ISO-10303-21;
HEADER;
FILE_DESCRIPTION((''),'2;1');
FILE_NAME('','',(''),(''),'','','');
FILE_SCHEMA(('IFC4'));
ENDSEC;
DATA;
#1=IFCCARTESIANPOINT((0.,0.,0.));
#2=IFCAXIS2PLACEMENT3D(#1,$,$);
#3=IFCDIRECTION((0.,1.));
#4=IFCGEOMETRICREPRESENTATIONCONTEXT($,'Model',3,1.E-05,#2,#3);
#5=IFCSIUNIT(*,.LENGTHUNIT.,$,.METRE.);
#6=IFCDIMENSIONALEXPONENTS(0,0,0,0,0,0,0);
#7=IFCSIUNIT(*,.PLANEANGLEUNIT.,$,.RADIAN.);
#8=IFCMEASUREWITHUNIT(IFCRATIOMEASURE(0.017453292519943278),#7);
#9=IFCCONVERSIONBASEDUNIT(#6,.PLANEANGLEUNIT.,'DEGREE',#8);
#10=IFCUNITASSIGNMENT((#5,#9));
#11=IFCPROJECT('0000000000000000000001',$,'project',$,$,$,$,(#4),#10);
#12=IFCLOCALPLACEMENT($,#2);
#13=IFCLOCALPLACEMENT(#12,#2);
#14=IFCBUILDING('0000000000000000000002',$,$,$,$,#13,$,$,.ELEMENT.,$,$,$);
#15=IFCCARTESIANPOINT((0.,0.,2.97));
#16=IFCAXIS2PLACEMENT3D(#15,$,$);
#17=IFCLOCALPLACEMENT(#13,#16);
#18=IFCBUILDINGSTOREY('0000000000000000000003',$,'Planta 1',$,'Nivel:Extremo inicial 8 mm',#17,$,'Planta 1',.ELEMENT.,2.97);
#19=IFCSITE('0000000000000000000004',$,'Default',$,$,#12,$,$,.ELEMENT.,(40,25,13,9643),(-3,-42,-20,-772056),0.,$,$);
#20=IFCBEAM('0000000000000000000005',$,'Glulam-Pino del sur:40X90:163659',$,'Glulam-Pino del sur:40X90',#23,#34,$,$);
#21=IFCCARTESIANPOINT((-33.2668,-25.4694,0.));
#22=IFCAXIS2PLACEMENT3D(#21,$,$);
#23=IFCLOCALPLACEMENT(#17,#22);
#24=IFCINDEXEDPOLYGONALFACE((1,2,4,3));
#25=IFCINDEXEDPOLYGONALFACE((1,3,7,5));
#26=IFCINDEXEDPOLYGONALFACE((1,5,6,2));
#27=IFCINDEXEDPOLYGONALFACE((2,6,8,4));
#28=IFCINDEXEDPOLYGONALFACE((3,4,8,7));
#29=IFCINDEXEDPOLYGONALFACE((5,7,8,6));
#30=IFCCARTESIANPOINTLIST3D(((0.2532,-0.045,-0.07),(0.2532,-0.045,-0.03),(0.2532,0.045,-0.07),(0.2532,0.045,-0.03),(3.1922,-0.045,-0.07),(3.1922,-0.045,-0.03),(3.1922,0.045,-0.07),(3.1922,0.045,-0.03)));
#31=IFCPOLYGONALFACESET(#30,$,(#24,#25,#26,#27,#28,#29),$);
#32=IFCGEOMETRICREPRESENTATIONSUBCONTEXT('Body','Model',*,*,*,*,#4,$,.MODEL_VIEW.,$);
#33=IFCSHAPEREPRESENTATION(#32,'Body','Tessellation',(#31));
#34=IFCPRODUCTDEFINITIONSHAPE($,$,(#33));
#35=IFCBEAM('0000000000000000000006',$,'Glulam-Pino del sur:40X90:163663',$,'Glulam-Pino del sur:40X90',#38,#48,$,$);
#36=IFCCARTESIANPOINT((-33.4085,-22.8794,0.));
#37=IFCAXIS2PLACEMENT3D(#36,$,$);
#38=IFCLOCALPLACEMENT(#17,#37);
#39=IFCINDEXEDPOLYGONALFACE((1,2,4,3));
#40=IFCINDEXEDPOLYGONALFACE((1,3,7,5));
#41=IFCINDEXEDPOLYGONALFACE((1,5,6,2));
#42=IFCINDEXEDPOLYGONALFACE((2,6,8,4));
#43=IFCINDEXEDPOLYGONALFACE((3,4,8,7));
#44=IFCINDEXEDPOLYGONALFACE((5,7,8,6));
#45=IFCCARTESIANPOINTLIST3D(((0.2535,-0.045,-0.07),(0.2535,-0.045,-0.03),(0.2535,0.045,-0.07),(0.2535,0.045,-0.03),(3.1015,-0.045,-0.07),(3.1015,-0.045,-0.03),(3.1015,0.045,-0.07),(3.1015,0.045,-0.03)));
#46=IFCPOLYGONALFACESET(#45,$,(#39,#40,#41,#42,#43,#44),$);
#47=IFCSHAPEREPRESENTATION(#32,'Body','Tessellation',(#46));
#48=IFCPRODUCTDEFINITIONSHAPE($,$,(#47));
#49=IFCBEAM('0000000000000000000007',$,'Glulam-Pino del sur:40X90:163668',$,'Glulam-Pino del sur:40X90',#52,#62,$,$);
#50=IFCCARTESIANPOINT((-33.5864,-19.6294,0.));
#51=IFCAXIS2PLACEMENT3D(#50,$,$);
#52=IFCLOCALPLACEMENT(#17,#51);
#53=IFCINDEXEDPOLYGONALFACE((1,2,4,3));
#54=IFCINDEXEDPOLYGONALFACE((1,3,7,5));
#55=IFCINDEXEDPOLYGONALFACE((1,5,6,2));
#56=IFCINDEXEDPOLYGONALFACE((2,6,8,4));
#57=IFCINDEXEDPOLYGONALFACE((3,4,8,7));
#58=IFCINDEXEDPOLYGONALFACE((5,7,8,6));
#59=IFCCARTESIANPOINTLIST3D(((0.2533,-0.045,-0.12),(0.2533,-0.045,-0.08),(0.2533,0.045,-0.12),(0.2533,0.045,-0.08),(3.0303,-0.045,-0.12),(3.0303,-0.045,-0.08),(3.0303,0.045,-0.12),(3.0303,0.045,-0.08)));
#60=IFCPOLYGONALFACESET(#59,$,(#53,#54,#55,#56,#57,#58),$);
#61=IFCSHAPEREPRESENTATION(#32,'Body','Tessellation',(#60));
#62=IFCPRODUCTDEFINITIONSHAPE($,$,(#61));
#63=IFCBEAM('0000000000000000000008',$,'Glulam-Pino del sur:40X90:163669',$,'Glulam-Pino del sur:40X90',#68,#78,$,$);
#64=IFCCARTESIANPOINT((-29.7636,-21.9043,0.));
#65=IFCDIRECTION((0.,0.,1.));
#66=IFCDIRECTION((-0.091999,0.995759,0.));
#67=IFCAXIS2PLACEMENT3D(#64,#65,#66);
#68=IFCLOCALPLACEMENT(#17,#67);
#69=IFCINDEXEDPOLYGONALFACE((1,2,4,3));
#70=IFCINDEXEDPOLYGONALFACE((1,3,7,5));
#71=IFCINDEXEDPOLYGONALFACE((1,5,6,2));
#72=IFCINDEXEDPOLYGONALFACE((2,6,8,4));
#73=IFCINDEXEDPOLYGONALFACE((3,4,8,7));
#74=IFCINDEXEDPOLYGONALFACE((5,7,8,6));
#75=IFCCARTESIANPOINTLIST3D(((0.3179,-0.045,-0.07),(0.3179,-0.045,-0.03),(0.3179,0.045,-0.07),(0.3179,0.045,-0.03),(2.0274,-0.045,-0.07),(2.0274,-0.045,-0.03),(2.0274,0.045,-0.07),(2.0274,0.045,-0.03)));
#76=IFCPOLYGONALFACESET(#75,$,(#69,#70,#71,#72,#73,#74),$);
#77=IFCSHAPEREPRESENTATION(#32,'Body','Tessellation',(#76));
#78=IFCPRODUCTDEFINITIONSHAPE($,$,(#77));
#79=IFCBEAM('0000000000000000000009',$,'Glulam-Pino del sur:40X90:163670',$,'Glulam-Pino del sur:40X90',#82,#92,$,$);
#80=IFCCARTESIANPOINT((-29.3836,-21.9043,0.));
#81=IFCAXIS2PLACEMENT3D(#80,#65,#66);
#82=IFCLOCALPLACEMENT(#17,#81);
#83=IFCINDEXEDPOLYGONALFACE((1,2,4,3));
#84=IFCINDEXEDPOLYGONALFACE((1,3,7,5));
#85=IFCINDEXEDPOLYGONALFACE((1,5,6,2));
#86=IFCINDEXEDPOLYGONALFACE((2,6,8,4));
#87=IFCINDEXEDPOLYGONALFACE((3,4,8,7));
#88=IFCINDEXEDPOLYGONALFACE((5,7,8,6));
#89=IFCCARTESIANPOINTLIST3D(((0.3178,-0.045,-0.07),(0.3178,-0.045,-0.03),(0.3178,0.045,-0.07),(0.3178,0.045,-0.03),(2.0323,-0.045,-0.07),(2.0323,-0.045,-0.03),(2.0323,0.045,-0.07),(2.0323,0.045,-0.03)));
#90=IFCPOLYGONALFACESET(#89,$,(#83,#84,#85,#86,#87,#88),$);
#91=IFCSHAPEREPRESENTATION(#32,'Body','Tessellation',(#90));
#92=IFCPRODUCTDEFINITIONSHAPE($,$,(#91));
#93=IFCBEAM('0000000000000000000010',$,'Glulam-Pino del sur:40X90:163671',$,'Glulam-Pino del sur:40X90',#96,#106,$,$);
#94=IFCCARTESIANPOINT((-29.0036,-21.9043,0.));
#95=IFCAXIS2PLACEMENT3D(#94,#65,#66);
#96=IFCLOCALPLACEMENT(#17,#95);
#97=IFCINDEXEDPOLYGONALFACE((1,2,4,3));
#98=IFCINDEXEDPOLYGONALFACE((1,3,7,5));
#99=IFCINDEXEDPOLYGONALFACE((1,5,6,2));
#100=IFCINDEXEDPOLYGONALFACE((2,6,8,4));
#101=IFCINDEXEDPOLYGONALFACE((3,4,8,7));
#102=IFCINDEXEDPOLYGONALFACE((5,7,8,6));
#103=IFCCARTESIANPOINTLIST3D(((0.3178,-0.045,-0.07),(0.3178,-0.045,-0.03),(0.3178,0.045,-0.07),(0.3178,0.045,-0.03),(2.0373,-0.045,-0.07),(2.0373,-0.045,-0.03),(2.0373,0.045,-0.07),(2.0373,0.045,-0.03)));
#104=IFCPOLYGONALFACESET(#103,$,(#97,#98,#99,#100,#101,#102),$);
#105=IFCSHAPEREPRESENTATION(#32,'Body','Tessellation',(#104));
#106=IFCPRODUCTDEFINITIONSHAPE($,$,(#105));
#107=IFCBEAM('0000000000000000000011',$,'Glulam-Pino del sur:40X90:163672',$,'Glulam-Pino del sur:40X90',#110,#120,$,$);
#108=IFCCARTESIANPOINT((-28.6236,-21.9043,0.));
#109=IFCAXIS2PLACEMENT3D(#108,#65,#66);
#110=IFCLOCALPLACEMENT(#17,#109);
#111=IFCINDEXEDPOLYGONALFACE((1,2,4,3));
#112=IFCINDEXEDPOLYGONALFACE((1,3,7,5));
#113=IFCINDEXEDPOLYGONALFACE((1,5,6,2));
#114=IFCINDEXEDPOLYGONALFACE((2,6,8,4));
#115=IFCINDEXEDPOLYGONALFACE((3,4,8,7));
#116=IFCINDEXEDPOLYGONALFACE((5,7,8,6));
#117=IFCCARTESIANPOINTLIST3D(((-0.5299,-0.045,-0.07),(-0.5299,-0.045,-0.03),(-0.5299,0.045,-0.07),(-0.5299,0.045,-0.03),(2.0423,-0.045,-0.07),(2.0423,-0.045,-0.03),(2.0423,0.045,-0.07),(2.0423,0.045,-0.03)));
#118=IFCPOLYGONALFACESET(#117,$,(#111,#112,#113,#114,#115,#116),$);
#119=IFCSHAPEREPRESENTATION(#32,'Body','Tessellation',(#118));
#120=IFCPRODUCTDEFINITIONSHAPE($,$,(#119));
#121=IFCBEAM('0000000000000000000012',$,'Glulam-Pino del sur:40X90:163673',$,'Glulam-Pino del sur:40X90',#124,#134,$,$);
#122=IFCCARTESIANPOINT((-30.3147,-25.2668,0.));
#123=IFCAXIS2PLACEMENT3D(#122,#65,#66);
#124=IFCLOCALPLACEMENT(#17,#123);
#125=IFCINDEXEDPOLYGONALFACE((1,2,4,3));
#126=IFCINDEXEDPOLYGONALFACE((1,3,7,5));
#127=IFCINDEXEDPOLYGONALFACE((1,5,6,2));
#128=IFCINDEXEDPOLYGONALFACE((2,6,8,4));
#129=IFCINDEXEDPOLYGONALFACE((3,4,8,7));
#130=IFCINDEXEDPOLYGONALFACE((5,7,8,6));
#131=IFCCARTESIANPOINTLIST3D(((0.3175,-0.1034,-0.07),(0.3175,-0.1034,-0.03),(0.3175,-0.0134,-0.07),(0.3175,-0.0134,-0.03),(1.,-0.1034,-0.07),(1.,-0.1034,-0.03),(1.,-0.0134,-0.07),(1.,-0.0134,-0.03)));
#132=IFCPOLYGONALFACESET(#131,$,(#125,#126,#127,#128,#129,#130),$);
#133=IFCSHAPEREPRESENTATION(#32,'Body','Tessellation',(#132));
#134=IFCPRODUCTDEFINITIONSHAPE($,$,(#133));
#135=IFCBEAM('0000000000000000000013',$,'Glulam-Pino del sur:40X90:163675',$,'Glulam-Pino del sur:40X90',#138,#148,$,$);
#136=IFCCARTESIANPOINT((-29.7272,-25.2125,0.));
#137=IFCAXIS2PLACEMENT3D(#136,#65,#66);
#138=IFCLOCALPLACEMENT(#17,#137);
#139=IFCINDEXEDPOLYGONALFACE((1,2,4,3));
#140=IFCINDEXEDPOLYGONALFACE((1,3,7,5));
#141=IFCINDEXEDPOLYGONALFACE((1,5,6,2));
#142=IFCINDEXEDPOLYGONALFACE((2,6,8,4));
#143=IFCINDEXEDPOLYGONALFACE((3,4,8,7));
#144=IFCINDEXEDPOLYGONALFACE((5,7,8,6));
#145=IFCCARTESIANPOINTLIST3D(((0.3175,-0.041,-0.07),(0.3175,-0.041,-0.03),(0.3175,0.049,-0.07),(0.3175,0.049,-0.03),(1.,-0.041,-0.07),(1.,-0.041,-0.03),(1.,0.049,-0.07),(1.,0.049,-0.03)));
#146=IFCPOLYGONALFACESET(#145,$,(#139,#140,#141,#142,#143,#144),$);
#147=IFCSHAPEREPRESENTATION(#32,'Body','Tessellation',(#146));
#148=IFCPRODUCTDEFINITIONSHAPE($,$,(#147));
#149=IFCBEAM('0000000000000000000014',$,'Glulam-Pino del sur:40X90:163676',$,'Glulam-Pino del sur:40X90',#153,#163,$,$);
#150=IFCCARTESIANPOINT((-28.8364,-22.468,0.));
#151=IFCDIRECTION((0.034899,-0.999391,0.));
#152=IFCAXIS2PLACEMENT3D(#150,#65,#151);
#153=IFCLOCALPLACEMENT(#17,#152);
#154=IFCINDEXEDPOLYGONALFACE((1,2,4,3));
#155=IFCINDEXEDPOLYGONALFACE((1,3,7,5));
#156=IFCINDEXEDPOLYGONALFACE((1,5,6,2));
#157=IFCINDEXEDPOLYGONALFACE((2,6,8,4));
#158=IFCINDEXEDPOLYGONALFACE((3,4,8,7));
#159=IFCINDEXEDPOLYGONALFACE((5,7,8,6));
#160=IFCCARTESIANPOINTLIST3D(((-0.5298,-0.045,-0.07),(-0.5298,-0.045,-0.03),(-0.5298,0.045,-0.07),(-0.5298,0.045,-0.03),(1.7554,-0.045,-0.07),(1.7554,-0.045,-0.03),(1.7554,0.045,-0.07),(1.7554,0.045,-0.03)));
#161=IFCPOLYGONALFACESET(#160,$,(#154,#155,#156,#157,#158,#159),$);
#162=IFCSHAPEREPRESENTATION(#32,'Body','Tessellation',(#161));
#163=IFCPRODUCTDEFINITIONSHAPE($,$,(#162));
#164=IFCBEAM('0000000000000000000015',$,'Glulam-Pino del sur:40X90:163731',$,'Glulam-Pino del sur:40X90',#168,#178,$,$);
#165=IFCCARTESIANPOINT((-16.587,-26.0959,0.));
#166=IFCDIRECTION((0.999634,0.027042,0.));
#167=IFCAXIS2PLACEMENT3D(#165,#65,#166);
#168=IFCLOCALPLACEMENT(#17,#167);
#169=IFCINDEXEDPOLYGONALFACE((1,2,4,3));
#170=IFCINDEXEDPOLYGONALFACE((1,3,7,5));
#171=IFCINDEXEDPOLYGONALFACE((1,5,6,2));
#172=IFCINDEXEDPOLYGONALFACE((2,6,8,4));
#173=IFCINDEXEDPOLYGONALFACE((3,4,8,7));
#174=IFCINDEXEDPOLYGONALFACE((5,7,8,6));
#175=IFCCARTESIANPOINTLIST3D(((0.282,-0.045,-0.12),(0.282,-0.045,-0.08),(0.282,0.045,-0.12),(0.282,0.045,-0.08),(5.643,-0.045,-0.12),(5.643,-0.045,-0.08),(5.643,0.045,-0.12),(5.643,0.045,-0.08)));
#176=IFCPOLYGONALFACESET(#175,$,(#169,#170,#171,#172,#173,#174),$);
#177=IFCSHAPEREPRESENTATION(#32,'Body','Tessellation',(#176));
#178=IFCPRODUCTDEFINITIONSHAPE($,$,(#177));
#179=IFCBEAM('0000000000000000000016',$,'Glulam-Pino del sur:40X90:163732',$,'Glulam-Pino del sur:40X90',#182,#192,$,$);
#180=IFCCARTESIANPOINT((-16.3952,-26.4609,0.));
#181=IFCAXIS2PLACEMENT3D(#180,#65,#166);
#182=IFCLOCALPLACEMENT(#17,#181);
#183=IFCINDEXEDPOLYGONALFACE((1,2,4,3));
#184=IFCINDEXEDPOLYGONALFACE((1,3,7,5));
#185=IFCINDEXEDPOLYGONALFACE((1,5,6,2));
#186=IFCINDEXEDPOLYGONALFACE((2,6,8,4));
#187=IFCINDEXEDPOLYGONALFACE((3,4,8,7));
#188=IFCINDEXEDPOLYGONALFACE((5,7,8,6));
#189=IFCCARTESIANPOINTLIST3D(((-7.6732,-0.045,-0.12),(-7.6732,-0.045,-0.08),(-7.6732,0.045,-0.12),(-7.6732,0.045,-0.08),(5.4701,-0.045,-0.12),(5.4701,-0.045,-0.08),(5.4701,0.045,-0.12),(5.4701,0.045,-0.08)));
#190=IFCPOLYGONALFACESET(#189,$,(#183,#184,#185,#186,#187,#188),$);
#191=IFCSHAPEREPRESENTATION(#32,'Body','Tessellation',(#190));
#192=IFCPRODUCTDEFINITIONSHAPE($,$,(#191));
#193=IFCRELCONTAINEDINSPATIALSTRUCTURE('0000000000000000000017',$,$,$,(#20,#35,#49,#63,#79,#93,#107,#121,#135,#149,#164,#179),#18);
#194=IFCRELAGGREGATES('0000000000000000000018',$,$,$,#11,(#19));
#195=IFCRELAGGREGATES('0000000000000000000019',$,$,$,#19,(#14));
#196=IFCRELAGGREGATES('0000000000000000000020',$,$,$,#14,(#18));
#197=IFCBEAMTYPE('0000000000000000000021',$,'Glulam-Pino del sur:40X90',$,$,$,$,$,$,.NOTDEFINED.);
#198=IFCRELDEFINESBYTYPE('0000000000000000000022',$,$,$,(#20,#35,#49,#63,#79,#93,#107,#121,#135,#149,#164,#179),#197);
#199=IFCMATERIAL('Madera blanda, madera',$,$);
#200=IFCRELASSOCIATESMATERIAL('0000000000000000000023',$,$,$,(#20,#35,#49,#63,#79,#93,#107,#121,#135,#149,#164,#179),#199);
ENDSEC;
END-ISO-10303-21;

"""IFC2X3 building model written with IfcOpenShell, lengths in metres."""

from ifc_helpers import new_model, entity, si_unit, converted_unit, direction, frame, frame_2d, origin, origin_2d_with_axis, place, context, subcontext, project, spatial, rectangle, extrude, material, type_object, element, save


model = new_model("IFC2X3")

# Units and contexts
model_context = context("Model", 3, precision=1e-05, world=origin(), true_north=direction((0.0, 1.0)))
body_context = subcontext(model_context, "Body", "Model", "MODEL_VIEW")
ifc_project = project(units=[si_unit("LENGTHUNIT", "METRE"), converted_unit("PLANEANGLEUNIT", "DEGREE", entity("IfcRatioMeasure", 0.017453292519943278), si_unit("PLANEANGLEUNIT", "RADIAN"), dimensions=[0, 0, 0, 0, 0, 0, 0])], contexts=[model_context])

# Site, building, storey
site_placement = place(None, origin())
site = spatial("IfcSite", under=ifc_project, at=site_placement, Name="Default", CompositionType="ELEMENT", RefLatitude=(40, 25, 13, 9643), RefLongitude=(-3, -42, -20, -772056), RefElevation=0.0)
building_placement = place(site_placement, origin())
building = spatial("IfcBuilding", under=site, at=building_placement, CompositionType="ELEMENT")
storey_placement = place(building_placement, frame((0.0, 0.0, 2.97)))
storey = spatial("IfcBuildingStorey", under=building, at=storey_placement, Name="Planta 1", ObjectType="Nivel:Extremo inicial 8 mm", LongName="Planta 1", CompositionType="ELEMENT", Elevation=2.97)

# Beams
ifc_material_1 = material(Name="Madera blanda, madera")
beam_type_1 = type_object("IfcBeamType", Name="Glulam-Pino del sur:40X90", PredefinedType="NOTDEFINED")
beam_1_placement = place(storey_placement, frame((-33.2668, -25.4694, 0.0)))
element("IfcBeam", 1, at=beam_1_placement, inside=storey, type_object=beam_type_1, material=ifc_material_1, Name="Glulam-Pino del sur:40X90:163659", ObjectType="Glulam-Pino del sur:40X90", context=body_context, shape_type="SweptSolid", body=[
    extrude(rectangle(XDim=0.04, YDim=0.09, at=frame_2d((0.0, 0.0), x_axis=(1.0, 0.0))), frame((0.2532, 0.0, -0.05), z_axis=(1.0, 0.0, 0.0), x_axis=(0.0, 0.0, -1.0)), (0.0, 0.0, 1.0), 2.939),
])
beam_2_placement = place(storey_placement, frame((-33.4085, -22.8794, 0.0)))
element("IfcBeam", 2, at=beam_2_placement, inside=storey, type_object=beam_type_1, material=ifc_material_1, Name="Glulam-Pino del sur:40X90:163663", ObjectType="Glulam-Pino del sur:40X90", context=body_context, shape_type="SweptSolid", body=[
    extrude(rectangle(XDim=0.04, YDim=0.09, at=frame_2d((0.0, 0.0), x_axis=(1.0, 0.0))), frame((0.2535, 0.0, -0.05), z_axis=(1.0, 0.0, 0.0), x_axis=(0.0, 0.0, -1.0)), (0.0, 0.0, 1.0), 2.848),
])
beam_3_placement = place(storey_placement, frame((-33.5864, -19.6294, 0.0)))
element("IfcBeam", 3, at=beam_3_placement, inside=storey, type_object=beam_type_1, material=ifc_material_1, Name="Glulam-Pino del sur:40X90:163668", ObjectType="Glulam-Pino del sur:40X90", context=body_context, shape_type="SweptSolid", body=[
    extrude(rectangle(XDim=0.04, YDim=0.09, at=origin_2d_with_axis()), frame((0.2533, 0.0, -0.1), z_axis=(1.0, 0.0, 0.0), x_axis=(0.0, 0.0, -1.0)), (0.0, 0.0, 1.0), 2.777),
])
beam_4_placement = place(storey_placement, frame((-29.7636, -21.9043, 0.0), z_axis=(0.0, 0.0, 1.0), x_axis=(-0.091999, 0.995759, 0.0)))
element("IfcBeam", 4, at=beam_4_placement, inside=storey, type_object=beam_type_1, material=ifc_material_1, Name="Glulam-Pino del sur:40X90:163669", ObjectType="Glulam-Pino del sur:40X90", context=body_context, shape_type="SweptSolid", body=[
    extrude(rectangle(XDim=0.04, YDim=0.09, at=frame_2d((0.0, 0.0), x_axis=(1.0, 0.0))), frame((0.3179, 0.0, -0.05), z_axis=(1.0, 0.0, 0.0), x_axis=(0.0, 0.0, -1.0)), (0.0, 0.0, 1.0), 1.7095),
])
beam_5_placement = place(storey_placement, frame((-29.3836, -21.9043, 0.0), z_axis=(0.0, 0.0, 1.0), x_axis=(-0.091999, 0.995759, 0.0)))
element("IfcBeam", 5, at=beam_5_placement, inside=storey, type_object=beam_type_1, material=ifc_material_1, Name="Glulam-Pino del sur:40X90:163670", ObjectType="Glulam-Pino del sur:40X90", context=body_context, shape_type="SweptSolid", body=[
    extrude(rectangle(XDim=0.04, YDim=0.09, at=frame_2d((0.0, 0.0), x_axis=(1.0, 0.0))), frame((0.3178, 0.0, -0.05), z_axis=(1.0, 0.0, 0.0), x_axis=(0.0, 0.0, -1.0)), (0.0, 0.0, 1.0), 1.7145),
])
beam_6_placement = place(storey_placement, frame((-29.0036, -21.9043, 0.0), z_axis=(0.0, 0.0, 1.0), x_axis=(-0.091999, 0.995759, 0.0)))
element("IfcBeam", 6, at=beam_6_placement, inside=storey, type_object=beam_type_1, material=ifc_material_1, Name="Glulam-Pino del sur:40X90:163671", ObjectType="Glulam-Pino del sur:40X90", context=body_context, shape_type="SweptSolid", body=[
    extrude(rectangle(XDim=0.04, YDim=0.09, at=frame_2d((0.0, 0.0), x_axis=(1.0, 0.0))), frame((0.3178, 0.0, -0.05), z_axis=(1.0, 0.0, 0.0), x_axis=(0.0, 0.0, -1.0)), (0.0, 0.0, 1.0), 1.7195),
])
beam_7_placement = place(storey_placement, frame((-28.6236, -21.9043, 0.0), z_axis=(0.0, 0.0, 1.0), x_axis=(-0.091999, 0.995759, 0.0)))
element("IfcBeam", 7, at=beam_7_placement, inside=storey, type_object=beam_type_1, material=ifc_material_1, Name="Glulam-Pino del sur:40X90:163672", ObjectType="Glulam-Pino del sur:40X90", context=body_context, shape_type="SweptSolid", body=[
    extrude(rectangle(XDim=0.04, YDim=0.09, at=frame_2d((0.0, 0.0), x_axis=(1.0, 0.0))), frame((-0.5299, 0.0, -0.05), z_axis=(1.0, 0.0, 0.0), x_axis=(0.0, 0.0, -1.0)), (0.0, 0.0, 1.0), 2.5722),
])
beam_8_placement = place(storey_placement, frame((-30.3147, -25.2668, 0.0), z_axis=(0.0, 0.0, 1.0), x_axis=(-0.091999, 0.995759, 0.0)))
element("IfcBeam", 8, at=beam_8_placement, inside=storey, type_object=beam_type_1, material=ifc_material_1, Name="Glulam-Pino del sur:40X90:163673", ObjectType="Glulam-Pino del sur:40X90", context=body_context, shape_type="SweptSolid", body=[
    extrude(rectangle(XDim=0.04, YDim=0.09, at=frame_2d((0.0, 0.0), x_axis=(1.0, 0.0))), frame((0.3175, -0.0584, -0.05), z_axis=(1.0, 0.0, 0.0), x_axis=(0.0, 0.0, -1.0)), (0.0, 0.0, 1.0), 0.6825),
])
beam_9_placement = place(storey_placement, frame((-29.7272, -25.2125, 0.0), z_axis=(0.0, 0.0, 1.0), x_axis=(-0.091999, 0.995759, 0.0)))
element("IfcBeam", 9, at=beam_9_placement, inside=storey, type_object=beam_type_1, material=ifc_material_1, Name="Glulam-Pino del sur:40X90:163675", ObjectType="Glulam-Pino del sur:40X90", context=body_context, shape_type="SweptSolid", body=[
    extrude(rectangle(XDim=0.04, YDim=0.09, at=frame_2d((0.0, 0.0), x_axis=(1.0, 0.0))), frame((0.3175, 0.004, -0.05), z_axis=(1.0, 0.0, 0.0), x_axis=(0.0, 0.0, -1.0)), (0.0, 0.0, 1.0), 0.6825),
])
beam_10_placement = place(storey_placement, frame((-28.8364, -22.468, 0.0), z_axis=(0.0, 0.0, 1.0), x_axis=(0.034899, -0.999391, 0.0)))
element("IfcBeam", 10, at=beam_10_placement, inside=storey, type_object=beam_type_1, material=ifc_material_1, Name="Glulam-Pino del sur:40X90:163676", ObjectType="Glulam-Pino del sur:40X90", context=body_context, shape_type="SweptSolid", body=[
    extrude(rectangle(XDim=0.04, YDim=0.09, at=frame_2d((0.0, 0.0), x_axis=(1.0, 0.0))), frame((-0.5298, 0.0, -0.05), z_axis=(1.0, 0.0, 0.0), x_axis=(0.0, 0.0, -1.0)), (0.0, 0.0, 1.0), 2.2852),
])
beam_11_placement = place(storey_placement, frame((-16.587, -26.0959, 0.0), z_axis=(0.0, 0.0, 1.0), x_axis=(0.999634, 0.027042, 0.0)))
element("IfcBeam", 11, at=beam_11_placement, inside=storey, type_object=beam_type_1, material=ifc_material_1, Name="Glulam-Pino del sur:40X90:163731", ObjectType="Glulam-Pino del sur:40X90", context=body_context, shape_type="SweptSolid", body=[
    extrude(rectangle(XDim=0.04, YDim=0.09, at=frame_2d((0.0, 0.0), x_axis=(1.0, 0.0))), frame((0.282, 0.0, -0.1), z_axis=(1.0, 0.0, 0.0), x_axis=(0.0, 0.0, -1.0)), (0.0, 0.0, 1.0), 5.361),
])
beam_12_placement = place(storey_placement, frame((-16.3952, -26.4609, 0.0), z_axis=(0.0, 0.0, 1.0), x_axis=(0.999634, 0.027042, 0.0)))
element("IfcBeam", 12, at=beam_12_placement, inside=storey, type_object=beam_type_1, material=ifc_material_1, Name="Glulam-Pino del sur:40X90:163732", ObjectType="Glulam-Pino del sur:40X90", context=body_context, shape_type="SweptSolid", body=[
    extrude(rectangle(XDim=0.04, YDim=0.09, at=frame_2d((0.0, 0.0), x_axis=(1.0, 0.0))), frame((-7.6732, 0.0, -0.1), z_axis=(1.0, 0.0, 0.0), x_axis=(0.0, 0.0, -1.0)), (0.0, 0.0, 1.0), 13.1433),
])

save(model, "model.ifc")
